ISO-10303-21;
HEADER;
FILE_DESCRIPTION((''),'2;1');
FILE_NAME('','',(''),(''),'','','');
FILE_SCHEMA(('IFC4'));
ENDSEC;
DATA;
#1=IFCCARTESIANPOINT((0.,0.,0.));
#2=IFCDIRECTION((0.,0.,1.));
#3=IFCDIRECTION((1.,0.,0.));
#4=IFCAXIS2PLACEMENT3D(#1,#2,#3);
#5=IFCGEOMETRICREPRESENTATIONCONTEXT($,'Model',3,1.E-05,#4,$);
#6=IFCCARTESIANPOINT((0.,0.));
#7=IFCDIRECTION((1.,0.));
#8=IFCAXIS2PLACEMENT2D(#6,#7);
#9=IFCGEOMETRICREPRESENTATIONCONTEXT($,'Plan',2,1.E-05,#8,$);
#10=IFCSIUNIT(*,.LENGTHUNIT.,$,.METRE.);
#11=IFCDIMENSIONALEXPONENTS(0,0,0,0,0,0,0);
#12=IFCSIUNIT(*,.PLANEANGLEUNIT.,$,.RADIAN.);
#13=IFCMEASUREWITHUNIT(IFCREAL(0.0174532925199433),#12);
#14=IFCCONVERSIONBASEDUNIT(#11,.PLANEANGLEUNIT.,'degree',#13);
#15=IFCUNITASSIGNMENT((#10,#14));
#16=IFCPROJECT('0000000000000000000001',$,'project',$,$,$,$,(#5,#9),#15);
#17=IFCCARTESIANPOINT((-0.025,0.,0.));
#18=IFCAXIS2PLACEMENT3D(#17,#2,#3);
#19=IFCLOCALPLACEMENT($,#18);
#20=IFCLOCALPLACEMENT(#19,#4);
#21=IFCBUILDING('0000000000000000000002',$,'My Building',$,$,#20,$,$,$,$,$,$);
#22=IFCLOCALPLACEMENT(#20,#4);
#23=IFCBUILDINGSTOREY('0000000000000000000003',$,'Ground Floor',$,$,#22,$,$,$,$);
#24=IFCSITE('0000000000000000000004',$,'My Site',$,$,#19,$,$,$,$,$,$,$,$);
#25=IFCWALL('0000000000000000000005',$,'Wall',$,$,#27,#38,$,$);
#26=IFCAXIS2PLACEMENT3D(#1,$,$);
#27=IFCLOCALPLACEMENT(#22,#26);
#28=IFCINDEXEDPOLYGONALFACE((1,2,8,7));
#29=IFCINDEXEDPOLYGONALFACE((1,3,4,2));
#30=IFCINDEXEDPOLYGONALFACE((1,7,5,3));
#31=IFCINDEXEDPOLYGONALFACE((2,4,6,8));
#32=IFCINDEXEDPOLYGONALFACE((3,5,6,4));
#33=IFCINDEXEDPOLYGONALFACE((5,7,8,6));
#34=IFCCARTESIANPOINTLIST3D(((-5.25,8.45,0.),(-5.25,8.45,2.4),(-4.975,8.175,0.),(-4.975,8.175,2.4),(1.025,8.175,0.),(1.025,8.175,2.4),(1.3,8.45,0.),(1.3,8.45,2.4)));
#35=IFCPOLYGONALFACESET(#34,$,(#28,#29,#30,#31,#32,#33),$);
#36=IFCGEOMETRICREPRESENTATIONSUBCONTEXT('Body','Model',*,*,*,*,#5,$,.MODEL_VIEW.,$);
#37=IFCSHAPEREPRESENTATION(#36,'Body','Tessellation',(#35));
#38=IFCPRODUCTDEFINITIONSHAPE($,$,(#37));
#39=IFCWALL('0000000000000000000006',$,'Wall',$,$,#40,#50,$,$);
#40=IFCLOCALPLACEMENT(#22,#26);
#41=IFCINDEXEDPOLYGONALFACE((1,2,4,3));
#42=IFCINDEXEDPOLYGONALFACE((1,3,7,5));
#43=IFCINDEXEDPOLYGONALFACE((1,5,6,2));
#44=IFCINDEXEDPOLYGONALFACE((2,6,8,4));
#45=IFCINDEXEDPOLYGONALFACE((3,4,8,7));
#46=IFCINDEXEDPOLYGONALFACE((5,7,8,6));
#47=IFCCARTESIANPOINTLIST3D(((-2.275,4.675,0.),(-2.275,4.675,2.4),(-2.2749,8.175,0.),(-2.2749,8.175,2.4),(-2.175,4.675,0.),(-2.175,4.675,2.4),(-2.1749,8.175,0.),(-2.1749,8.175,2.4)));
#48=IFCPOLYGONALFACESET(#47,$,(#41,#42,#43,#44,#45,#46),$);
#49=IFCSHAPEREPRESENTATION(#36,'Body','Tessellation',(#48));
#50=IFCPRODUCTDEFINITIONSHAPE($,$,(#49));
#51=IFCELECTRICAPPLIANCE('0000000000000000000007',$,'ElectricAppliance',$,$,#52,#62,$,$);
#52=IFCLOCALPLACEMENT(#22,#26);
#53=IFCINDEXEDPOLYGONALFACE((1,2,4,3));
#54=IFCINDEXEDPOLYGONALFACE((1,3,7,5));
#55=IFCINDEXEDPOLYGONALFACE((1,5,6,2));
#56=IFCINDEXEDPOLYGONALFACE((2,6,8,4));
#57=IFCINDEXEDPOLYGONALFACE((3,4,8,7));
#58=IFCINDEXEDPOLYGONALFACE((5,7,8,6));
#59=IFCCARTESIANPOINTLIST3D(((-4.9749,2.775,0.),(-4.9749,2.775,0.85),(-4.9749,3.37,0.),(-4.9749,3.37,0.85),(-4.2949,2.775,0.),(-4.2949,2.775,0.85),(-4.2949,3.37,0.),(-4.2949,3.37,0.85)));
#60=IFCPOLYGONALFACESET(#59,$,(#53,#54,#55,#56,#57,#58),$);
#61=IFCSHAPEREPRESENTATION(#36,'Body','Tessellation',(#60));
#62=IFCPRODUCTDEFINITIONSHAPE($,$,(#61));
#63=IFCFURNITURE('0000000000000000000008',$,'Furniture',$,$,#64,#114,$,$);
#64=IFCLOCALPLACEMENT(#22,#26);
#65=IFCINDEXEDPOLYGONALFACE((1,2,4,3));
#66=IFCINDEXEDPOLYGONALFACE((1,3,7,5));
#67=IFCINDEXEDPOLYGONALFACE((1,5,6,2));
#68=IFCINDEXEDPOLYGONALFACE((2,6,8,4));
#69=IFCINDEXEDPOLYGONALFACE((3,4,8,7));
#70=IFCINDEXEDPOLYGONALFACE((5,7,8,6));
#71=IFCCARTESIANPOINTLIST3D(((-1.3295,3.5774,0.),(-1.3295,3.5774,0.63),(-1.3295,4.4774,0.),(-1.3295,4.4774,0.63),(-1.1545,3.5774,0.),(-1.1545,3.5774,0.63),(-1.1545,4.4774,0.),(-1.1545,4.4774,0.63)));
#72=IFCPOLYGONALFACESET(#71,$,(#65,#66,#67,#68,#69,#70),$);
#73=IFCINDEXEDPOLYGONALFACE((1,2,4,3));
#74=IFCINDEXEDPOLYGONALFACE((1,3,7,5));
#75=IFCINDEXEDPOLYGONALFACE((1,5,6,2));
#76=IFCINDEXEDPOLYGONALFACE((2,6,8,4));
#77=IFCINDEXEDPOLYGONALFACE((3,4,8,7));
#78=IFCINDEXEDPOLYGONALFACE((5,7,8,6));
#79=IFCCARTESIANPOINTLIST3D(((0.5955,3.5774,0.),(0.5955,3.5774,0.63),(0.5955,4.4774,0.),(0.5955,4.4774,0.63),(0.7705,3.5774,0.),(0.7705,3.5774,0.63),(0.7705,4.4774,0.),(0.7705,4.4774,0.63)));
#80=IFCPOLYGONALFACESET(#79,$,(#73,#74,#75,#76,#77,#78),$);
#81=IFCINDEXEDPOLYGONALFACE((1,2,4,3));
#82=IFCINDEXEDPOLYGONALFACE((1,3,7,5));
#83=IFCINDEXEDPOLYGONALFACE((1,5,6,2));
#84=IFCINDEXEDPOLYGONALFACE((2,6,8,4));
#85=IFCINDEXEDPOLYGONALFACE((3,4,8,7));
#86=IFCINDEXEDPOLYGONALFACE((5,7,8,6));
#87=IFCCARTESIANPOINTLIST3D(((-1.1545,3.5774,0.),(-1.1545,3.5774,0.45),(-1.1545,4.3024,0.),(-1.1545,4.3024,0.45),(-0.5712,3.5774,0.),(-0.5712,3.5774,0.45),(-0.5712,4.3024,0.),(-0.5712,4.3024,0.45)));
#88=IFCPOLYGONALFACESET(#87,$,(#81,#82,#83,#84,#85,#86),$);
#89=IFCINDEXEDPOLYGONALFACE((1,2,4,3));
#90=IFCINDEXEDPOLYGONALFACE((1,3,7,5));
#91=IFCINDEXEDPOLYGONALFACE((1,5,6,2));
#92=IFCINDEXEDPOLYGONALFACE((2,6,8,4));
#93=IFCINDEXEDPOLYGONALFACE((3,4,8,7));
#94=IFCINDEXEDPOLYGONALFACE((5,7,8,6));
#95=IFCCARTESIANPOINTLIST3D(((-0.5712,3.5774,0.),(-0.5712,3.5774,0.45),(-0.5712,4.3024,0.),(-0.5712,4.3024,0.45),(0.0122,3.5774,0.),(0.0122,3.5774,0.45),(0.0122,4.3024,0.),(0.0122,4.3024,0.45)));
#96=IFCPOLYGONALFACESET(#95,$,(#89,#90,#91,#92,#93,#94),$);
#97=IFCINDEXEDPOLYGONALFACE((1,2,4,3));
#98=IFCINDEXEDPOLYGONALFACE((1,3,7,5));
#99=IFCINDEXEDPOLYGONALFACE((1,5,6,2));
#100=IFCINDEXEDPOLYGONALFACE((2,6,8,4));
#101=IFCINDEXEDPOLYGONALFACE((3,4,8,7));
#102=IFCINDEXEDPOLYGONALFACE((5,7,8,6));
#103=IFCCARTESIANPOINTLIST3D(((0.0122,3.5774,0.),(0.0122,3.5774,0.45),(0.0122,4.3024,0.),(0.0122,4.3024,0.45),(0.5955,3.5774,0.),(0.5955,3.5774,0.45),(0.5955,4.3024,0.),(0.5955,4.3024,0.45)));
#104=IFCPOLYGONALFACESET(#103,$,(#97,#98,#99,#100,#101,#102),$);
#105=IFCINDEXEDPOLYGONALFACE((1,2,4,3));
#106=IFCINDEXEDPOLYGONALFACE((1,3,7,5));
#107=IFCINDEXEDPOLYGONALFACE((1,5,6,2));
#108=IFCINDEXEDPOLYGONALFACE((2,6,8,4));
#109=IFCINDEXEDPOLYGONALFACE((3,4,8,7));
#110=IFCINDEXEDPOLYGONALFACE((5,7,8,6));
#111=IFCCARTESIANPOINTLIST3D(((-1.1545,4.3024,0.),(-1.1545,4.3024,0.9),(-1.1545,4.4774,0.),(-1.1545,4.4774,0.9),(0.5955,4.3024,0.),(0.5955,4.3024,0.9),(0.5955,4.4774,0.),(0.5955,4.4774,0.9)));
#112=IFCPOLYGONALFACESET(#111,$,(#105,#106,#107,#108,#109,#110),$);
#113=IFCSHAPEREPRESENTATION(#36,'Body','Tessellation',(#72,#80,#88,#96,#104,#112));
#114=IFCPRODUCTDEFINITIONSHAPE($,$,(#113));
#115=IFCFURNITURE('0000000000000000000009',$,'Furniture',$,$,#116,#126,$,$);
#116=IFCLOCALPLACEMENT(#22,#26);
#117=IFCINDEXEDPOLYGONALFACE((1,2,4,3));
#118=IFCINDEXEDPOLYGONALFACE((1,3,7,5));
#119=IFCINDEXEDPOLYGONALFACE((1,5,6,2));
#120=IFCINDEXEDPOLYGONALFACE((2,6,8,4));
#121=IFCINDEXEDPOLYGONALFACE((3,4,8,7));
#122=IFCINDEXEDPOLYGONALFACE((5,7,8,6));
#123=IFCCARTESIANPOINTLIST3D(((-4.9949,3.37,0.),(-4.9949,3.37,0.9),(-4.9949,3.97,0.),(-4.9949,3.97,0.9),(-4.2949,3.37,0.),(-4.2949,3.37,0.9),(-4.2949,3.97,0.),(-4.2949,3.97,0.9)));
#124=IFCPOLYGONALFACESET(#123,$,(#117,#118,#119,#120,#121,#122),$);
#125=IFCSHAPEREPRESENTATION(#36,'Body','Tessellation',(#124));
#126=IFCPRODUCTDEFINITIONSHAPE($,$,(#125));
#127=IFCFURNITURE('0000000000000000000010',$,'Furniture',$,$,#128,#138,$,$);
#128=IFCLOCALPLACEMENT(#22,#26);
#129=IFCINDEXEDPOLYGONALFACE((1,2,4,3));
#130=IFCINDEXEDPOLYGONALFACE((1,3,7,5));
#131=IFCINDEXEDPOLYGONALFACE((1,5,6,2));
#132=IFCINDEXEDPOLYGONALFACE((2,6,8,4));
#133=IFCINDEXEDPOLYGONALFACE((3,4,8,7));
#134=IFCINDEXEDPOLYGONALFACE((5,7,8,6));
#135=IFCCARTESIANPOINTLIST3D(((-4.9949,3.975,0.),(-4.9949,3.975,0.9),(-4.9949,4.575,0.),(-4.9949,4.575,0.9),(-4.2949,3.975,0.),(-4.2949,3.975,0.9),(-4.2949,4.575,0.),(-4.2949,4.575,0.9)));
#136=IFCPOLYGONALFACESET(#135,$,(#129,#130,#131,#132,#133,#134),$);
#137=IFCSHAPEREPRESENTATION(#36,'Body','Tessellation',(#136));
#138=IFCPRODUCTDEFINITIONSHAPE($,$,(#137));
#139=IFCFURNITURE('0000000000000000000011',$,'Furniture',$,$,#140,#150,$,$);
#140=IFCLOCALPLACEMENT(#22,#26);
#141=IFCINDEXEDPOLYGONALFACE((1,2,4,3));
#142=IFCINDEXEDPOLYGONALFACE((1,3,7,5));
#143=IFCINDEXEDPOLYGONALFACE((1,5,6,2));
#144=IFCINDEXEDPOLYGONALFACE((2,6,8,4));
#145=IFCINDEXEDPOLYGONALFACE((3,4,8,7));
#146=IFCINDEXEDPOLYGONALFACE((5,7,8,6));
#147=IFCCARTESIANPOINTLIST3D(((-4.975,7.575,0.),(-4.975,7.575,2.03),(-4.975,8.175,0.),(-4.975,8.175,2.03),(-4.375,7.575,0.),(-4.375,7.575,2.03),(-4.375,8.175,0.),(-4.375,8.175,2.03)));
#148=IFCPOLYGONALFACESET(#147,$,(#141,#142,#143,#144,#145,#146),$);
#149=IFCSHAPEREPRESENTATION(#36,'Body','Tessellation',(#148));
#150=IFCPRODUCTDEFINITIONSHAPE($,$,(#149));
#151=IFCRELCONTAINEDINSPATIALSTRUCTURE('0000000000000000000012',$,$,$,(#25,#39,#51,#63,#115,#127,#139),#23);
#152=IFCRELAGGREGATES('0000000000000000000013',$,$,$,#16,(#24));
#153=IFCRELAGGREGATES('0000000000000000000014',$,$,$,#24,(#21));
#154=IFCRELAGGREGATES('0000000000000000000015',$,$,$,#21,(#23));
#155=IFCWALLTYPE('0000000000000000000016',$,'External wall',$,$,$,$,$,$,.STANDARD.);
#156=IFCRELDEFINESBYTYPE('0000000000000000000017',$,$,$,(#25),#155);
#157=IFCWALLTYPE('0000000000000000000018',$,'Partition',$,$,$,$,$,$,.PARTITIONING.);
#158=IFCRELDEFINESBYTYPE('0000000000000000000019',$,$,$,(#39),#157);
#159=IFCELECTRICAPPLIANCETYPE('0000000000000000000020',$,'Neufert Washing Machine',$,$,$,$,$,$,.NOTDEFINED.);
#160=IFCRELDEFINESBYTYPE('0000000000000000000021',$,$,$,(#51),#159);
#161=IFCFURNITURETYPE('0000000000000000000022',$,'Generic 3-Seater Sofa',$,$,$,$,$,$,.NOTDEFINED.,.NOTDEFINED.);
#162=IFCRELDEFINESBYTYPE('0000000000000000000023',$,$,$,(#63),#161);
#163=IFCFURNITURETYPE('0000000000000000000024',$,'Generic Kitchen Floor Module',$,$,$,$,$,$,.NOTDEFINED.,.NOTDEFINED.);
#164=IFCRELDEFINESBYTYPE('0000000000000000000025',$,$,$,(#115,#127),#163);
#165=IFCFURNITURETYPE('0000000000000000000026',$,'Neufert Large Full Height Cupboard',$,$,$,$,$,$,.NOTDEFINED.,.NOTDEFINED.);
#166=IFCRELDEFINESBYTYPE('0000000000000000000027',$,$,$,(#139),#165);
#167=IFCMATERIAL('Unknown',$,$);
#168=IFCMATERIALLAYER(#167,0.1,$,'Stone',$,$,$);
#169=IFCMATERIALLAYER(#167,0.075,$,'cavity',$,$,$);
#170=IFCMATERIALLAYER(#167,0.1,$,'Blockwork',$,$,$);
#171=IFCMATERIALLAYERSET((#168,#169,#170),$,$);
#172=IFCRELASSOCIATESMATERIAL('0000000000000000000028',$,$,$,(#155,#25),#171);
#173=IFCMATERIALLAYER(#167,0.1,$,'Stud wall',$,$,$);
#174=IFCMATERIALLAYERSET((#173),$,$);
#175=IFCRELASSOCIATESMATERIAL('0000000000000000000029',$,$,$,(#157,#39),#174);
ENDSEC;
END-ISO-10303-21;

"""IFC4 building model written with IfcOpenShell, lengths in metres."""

from ifc_helpers import new_model, entity, si_unit, converted_unit, frame, origin_with_axes, origin_2d_with_axis, place, context, subcontext, project, spatial, line, indexed_curve, outline, extrude, clip, halfspace, shape, source, transform, mapped, material, layer, layer_set, layer_usage, type_object, type_shapes, element, save


model = new_model("IFC4")

# Units and contexts
model_context = context("Model", 3, precision=1e-05, world=origin_with_axes())
plan_context = context("Plan", 2, precision=1e-05, world=origin_2d_with_axis())
body_context_1 = subcontext(model_context, "Body", "Model", "MODEL_VIEW")
body_context_2 = subcontext(plan_context, "Body", "Plan", "PLAN_VIEW")
ifc_project = project(units=[si_unit("LENGTHUNIT", "METRE"), converted_unit("PLANEANGLEUNIT", "degree", entity("IfcReal", 0.0174532925199433), si_unit("PLANEANGLEUNIT", "RADIAN"), dimensions=[0, 0, 0, 0, 0, 0, 0])], contexts=[model_context, plan_context])

# Site, building, storey
site_placement = place(None, frame((-0.025, 0.0, 0.0), z_axis=(0.0, 0.0, 1.0), x_axis=(1.0, 0.0, 0.0)))
site = spatial("IfcSite", under=ifc_project, at=site_placement, Name="My Site")
building_placement = place(site_placement, origin_with_axes())
building = spatial("IfcBuilding", under=site, at=building_placement, Name="My Building")
storey_placement = place(building_placement, frame((0.0, 0.0, 0.0), z_axis=(0.0, 0.0, 1.0), x_axis=(1.0, 0.0, 0.0)))
storey = spatial("IfcBuildingStorey", under=building, at=storey_placement, Name="Ground Floor")

# Wall
ifc_material = material(Name="Unknown")
ifc_layer_1 = layer(ifc_material, 0.1, Name="Stone")
ifc_layer_2 = layer(ifc_material, 0.075, Name="cavity")
ifc_layer_3 = layer(ifc_material, 0.1, Name="Blockwork")
ifc_layer_set_1 = layer_set([ifc_layer_1, ifc_layer_2, ifc_layer_3])
ifc_layer_usage_1 = layer_usage(ifc_layer_set_1, "AXIS2", "POSITIVE", 0.0)
wall_type_1 = type_object("IfcWallType", Name="External wall", PredefinedType="STANDARD", material=ifc_layer_set_1)
wall_1_placement = place(storey_placement, frame((1.3, 8.45, 0.0), z_axis=(0.0, 0.0, 1.0), x_axis=(-1.0, 0.0, 0.0)))
element("IfcWall", 1, at=wall_1_placement, inside=storey, type_object=wall_type_1, material=ifc_layer_usage_1, Name="Wall", shapes=[
    shape(body_context_1, "Body", "Clipping", [clip(clip(extrude(outline(indexed_curve([(0.0, 0.0), (0.0, 0.275), (6.55, 0.275), (6.55, 0.0), (0.0, 0.0)], self_intersect=False)), origin_with_axes(), (0.0, 0.0, 1.0), 2.4), halfspace(frame((6.55, 0.0, 0.0), z_axis=(0.707106, 0.707107, 0.0), x_axis=(0.707107, -0.707106, 0.0)), False)), halfspace(frame((0.0, 0.0, 0.0), z_axis=(-0.707106, 0.707107, 0.0), x_axis=(0.707108, 0.707106, 0.0)), False))]),
    shape(body_context_1, "Body", "Clipping", [clip(clip(extrude(outline(indexed_curve([(0.0, 0.0), (0.0, 0.275), (6.55, 0.275), (6.55, 0.0), (0.0, 0.0)], self_intersect=False)), origin_with_axes(), (0.0, 0.0, 1.0), 2.4), halfspace(frame((6.55, 0.0, 0.0), z_axis=(0.707106, 0.707107, 0.0), x_axis=(0.707107, -0.707106, 0.0)), False)), halfspace(frame((0.0, 0.0, 0.0), z_axis=(-0.707106, 0.707107, 0.0), x_axis=(0.707108, 0.707106, 0.0)), False))]),
])

# Shared definitions
ifc_layer_4 = layer(ifc_material, 0.1, Name="Stud wall")
ifc_layer_set_2 = layer_set([ifc_layer_4])
wall_type_2 = type_object("IfcWallType", Name="Partition", PredefinedType="PARTITIONING", material=ifc_layer_set_2)

# Wall
ifc_layer_usage_2 = layer_usage(ifc_layer_set_2, "AXIS2", "POSITIVE", 0.0)
wall_2_placement = place(storey_placement, frame((-2.175, 4.675, 0.0), z_axis=(0.0, 0.0, 1.0), x_axis=(0.0, 1.0, 0.0)))
element("IfcWall", 2, at=wall_2_placement, inside=storey, type_object=wall_type_2, material=ifc_layer_usage_2, Name="Wall", context=body_context_1, shape_type="SweptSolid", body=[
    extrude(outline(indexed_curve([(0.0, 0.0), (0.0, 0.1), (3.5, 0.1), (3.5, 0.0), (0.0, 0.0)], self_intersect=False)), origin_with_axes(), (0.0, 0.0, 1.0), 2.4),
])

# Electric appliance
electric_appliance_type_1 = type_object("IfcElectricApplianceType", Name="Neufert Washing Machine", PredefinedType="NOTDEFINED")
shared_shape_1 = source(origin_with_axes(), body_context_1, "Body", "SweptSolid", [
    extrude(outline(indexed_curve([(0.0, 0.0), (0.595, 0.0), (0.595, 0.68), (0.0, 0.68)], segments=[line(1, 2, 3, 4, 1)])), origin_with_axes(), (0.0, 0.0, 1.0), 0.85),
])
shared_shape_2 = source(origin_with_axes(), body_context_2, "Body", "Curve2D", [
    entity("IfcIndexedPolyCurve", entity("IfcCartesianPointList2D", [[0.0, 0.0], [0.595, 0.0], [0.595, 0.68], [0.0, 0.68]]), [entity("IfcLineIndex", [1, 2, 3, 4, 1])]),
    entity("IfcCircle", entity("IfcAxis2Placement2D", entity("IfcCartesianPoint", [0.2975, 0.34])), 0.1785),
    entity("IfcCircle", entity("IfcAxis2Placement2D", entity("IfcCartesianPoint", [0.2975, 0.34])), 0.0595),
])
type_shapes(electric_appliance_type_1, [shared_shape_1, shared_shape_2])
electric_appliance_1_placement = place(storey_placement, frame((-4.2949, 2.775, 0.0), z_axis=(0.0, 0.0, 1.0), x_axis=(0.0, 1.0, 0.0)))
element("IfcElectricAppliance", 3, at=electric_appliance_1_placement, inside=storey, type_object=electric_appliance_type_1, Name="ElectricAppliance", shapes=[
    shape(body_context_1, "Body", "MappedRepresentation", [mapped(shared_shape_1, transform((0.0, 0.0, 0.0), x_axis=(1.0, 0.0, 0.0), y_axis=(0.0, 1.0, 0.0), z_axis=(0.0, 0.0, 1.0), scale=1.0))]),
    shape(body_context_2, "Body", "MappedRepresentation", [mapped(shared_shape_2, transform((0.0, 0.0, 0.0), x_axis=(1.0, 0.0, 0.0), y_axis=(0.0, 1.0, 0.0), z_axis=(0.0, 0.0, 1.0), scale=1.0))]),
])

# Furniture
furniture_type_1 = type_object("IfcFurnitureType", Name="Generic 3-Seater Sofa", AssemblyPlace="NOTDEFINED", PredefinedType="NOTDEFINED")
shared_shape_3 = source(origin_with_axes(), body_context_1, "Body", "SweptSolid", [
    extrude(outline(indexed_curve([(0.0, 0.0), (0.175, 0.0), (0.175, 0.9), (0.0, 0.9)], segments=[line(1, 2, 3, 4, 1)])), frame((-1.05, -0.9, 0.0), z_axis=(0.0, 0.0, 1.0), x_axis=(1.0, 0.0, 0.0)), (0.0, 0.0, 1.0), 0.63),
    extrude(outline(indexed_curve([(0.0, 0.0), (0.175, 0.0), (0.175, 0.9), (0.0, 0.9)], segments=[line(1, 2, 3, 4, 1)])), frame((0.875, -0.9, 0.0), z_axis=(0.0, 0.0, 1.0), x_axis=(1.0, 0.0, 0.0)), (0.0, 0.0, 1.0), 0.63),
    extrude(outline(indexed_curve([(0.175, 0.0), (0.7583, 0.0), (0.7583, 0.725), (0.175, 0.725)], segments=[line(1, 2, 3, 4, 1)])), frame((-1.05, -0.9, 0.0), z_axis=(0.0, 0.0, 1.0), x_axis=(1.0, 0.0, 0.0)), (0.0, 0.0, 1.0), 0.45),
    extrude(outline(indexed_curve([(0.7583, 0.0), (1.3417, 0.0), (1.3417, 0.725), (0.7583, 0.725)], segments=[line(1, 2, 3, 4, 1)])), frame((-1.05, -0.9, 0.0), z_axis=(0.0, 0.0, 1.0), x_axis=(1.0, 0.0, 0.0)), (0.0, 0.0, 1.0), 0.45),
    extrude(outline(indexed_curve([(1.3417, 0.0), (1.925, 0.0), (1.925, 0.725), (1.3417, 0.725)], segments=[line(1, 2, 3, 4, 1)])), frame((-1.05, -0.9, 0.0), z_axis=(0.0, 0.0, 1.0), x_axis=(1.0, 0.0, 0.0)), (0.0, 0.0, 1.0), 0.45),
    extrude(outline(indexed_curve([(0.175, 0.725), (1.925, 0.725), (1.925, 0.9), (0.175, 0.9)], segments=[line(1, 2, 3, 4, 1)])), frame((-1.05, -0.9, 0.0), z_axis=(0.0, 0.0, 1.0), x_axis=(1.0, 0.0, 0.0)), (0.0, 0.0, 1.0), 0.9),
])
shared_shape_4 = source(origin_with_axes(), body_context_2, "Body", "Curve2D", [
    entity("IfcIndexedPolyCurve", entity("IfcCartesianPointList2D", [[-1.05, -0.9], [-0.875, -0.9], [-0.875, 0.0], [-1.05, 0.0]]), [entity("IfcLineIndex", [1, 2, 3, 4, 1])]),
    entity("IfcIndexedPolyCurve", entity("IfcCartesianPointList2D", [[0.875, -0.9], [1.05, -0.9], [1.05, 0.0], [0.875, 0.0]]), [entity("IfcLineIndex", [1, 2, 3, 4, 1])]),
    entity("IfcIndexedPolyCurve", entity("IfcCartesianPointList2D", [[-0.875, -0.9], [-0.2917, -0.9], [-0.2917, -0.175], [-0.875, -0.175]]), [entity("IfcLineIndex", [1, 2, 3, 4, 1])]),
    entity("IfcIndexedPolyCurve", entity("IfcCartesianPointList2D", [[-0.2917, -0.9], [0.2917, -0.9], [0.2917, -0.175], [-0.2917, -0.175]]), [entity("IfcLineIndex", [1, 2, 3, 4, 1])]),
    entity("IfcIndexedPolyCurve", entity("IfcCartesianPointList2D", [[0.2917, -0.9], [0.875, -0.9], [0.875, -0.175], [0.2917, -0.175]]), [entity("IfcLineIndex", [1, 2, 3, 4, 1])]),
    entity("IfcIndexedPolyCurve", entity("IfcCartesianPointList2D", [[-0.875, -0.175], [0.875, -0.175], [0.875, 0.0], [-0.875, 0.0]]), [entity("IfcLineIndex", [1, 2, 3, 4, 1])]),
])
type_shapes(furniture_type_1, [shared_shape_3, shared_shape_4])
furniture_1_placement = place(storey_placement, frame((-0.2795, 4.4774, 0.0), z_axis=(0.0, 0.0, 1.0), x_axis=(1.0, 0.0, 0.0)))
element("IfcFurniture", 4, at=furniture_1_placement, inside=storey, type_object=furniture_type_1, Name="Furniture", shapes=[
    shape(body_context_1, "Body", "MappedRepresentation", [mapped(shared_shape_3, transform((0.0, 0.0, 0.0), x_axis=(1.0, 0.0, 0.0), y_axis=(0.0, 1.0, 0.0), z_axis=(0.0, 0.0, 1.0), scale=1.0))]),
    shape(body_context_2, "Body", "MappedRepresentation", [mapped(shared_shape_4, transform((0.0, 0.0, 0.0), x_axis=(1.0, 0.0, 0.0), y_axis=(0.0, 1.0, 0.0), z_axis=(0.0, 0.0, 1.0), scale=1.0))]),
])
furniture_type_2 = type_object("IfcFurnitureType", Name="Generic Kitchen Floor Module", AssemblyPlace="NOTDEFINED", PredefinedType="NOTDEFINED")
shared_shape_5 = source(origin_with_axes(), body_context_1, "Body", "SweptSolid", [
    extrude(outline(indexed_curve([(0.0, 0.0), (0.6, 0.0), (0.6, 0.7), (0.0, 0.7)], segments=[line(1, 2, 3, 4, 1)])), origin_with_axes(), (0.0, 0.0, 1.0), 0.9),
])
shared_shape_6 = source(origin_with_axes(), body_context_2, "Body", "Curve2D", [
    entity("IfcIndexedPolyCurve", entity("IfcCartesianPointList2D", [[0.0, 0.0], [0.6, 0.0], [0.6, 0.7], [0.0, 0.7]]), [entity("IfcLineIndex", [1, 2, 3, 4, 1])]),
])
type_shapes(furniture_type_2, [shared_shape_5, shared_shape_6])
for number, where, z_axis, x_axis, name in (
    (5, (-4.2949, 3.37, 0.0), (0.0, 0.0, 1.0), (0.0, 1.0, 0.0), "Furniture"),
    (6, (-4.2949, 3.975, 0.0), (0.0, 0.0, 1.0), (0.0, 1.0, 0.0), "Furniture"),
):
    element("IfcFurniture", number, at=place(storey_placement, frame(where, z_axis=z_axis, x_axis=x_axis)), inside=storey, type_object=furniture_type_2, Name=name, shapes=[
        shape(body_context_1, "Body", "MappedRepresentation", [mapped(shared_shape_5, transform((0.0, 0.0, 0.0), x_axis=(1.0, 0.0, 0.0), y_axis=(0.0, 1.0, 0.0), z_axis=(0.0, 0.0, 1.0), scale=1.0))]),
        shape(body_context_2, "Body", "MappedRepresentation", [mapped(shared_shape_6, transform((0.0, 0.0, 0.0), x_axis=(1.0, 0.0, 0.0), y_axis=(0.0, 1.0, 0.0), z_axis=(0.0, 0.0, 1.0), scale=1.0))]),
    ])
furniture_type_3 = type_object("IfcFurnitureType", Name="Neufert Large Full Height Cupboard", AssemblyPlace="NOTDEFINED", PredefinedType="NOTDEFINED")
shared_shape_7 = source(origin_with_axes(), body_context_1, "Body", "SweptSolid", [
    extrude(outline(indexed_curve([(0.0, 0.0), (0.6, 0.0), (0.6, 0.6), (0.0, 0.6)], segments=[line(1, 2, 3, 4, 1)])), origin_with_axes(), (0.0, 0.0, 1.0), 2.03),
])
shared_shape_8 = source(origin_with_axes(), body_context_2, "Body", "Curve2D", [
    entity("IfcIndexedPolyCurve", entity("IfcCartesianPointList2D", [[0.0, 0.0], [0.6, 0.0], [0.6, 0.6], [0.0, 0.6]]), [entity("IfcLineIndex", [1, 2, 3, 4, 1])]),
])
type_shapes(furniture_type_3, [shared_shape_7, shared_shape_8])
furniture_2_placement = place(storey_placement, frame((-4.975, 7.575, 0.0), z_axis=(0.0, 0.0, 1.0), x_axis=(1.0, 0.0, 0.0)))
element("IfcFurniture", 7, at=furniture_2_placement, inside=storey, type_object=furniture_type_3, Name="Furniture", shapes=[
    shape(body_context_1, "Body", "MappedRepresentation", [mapped(shared_shape_7, transform((0.0, 0.0, 0.0), x_axis=(1.0, 0.0, 0.0), y_axis=(0.0, 1.0, 0.0), z_axis=(0.0, 0.0, 1.0), scale=1.0))]),
    shape(body_context_2, "Body", "MappedRepresentation", [mapped(shared_shape_8, transform((0.0, 0.0, 0.0), x_axis=(1.0, 0.0, 0.0), y_axis=(0.0, 1.0, 0.0), z_axis=(0.0, 0.0, 1.0), scale=1.0))]),
])

save(model, "model.ifc")
